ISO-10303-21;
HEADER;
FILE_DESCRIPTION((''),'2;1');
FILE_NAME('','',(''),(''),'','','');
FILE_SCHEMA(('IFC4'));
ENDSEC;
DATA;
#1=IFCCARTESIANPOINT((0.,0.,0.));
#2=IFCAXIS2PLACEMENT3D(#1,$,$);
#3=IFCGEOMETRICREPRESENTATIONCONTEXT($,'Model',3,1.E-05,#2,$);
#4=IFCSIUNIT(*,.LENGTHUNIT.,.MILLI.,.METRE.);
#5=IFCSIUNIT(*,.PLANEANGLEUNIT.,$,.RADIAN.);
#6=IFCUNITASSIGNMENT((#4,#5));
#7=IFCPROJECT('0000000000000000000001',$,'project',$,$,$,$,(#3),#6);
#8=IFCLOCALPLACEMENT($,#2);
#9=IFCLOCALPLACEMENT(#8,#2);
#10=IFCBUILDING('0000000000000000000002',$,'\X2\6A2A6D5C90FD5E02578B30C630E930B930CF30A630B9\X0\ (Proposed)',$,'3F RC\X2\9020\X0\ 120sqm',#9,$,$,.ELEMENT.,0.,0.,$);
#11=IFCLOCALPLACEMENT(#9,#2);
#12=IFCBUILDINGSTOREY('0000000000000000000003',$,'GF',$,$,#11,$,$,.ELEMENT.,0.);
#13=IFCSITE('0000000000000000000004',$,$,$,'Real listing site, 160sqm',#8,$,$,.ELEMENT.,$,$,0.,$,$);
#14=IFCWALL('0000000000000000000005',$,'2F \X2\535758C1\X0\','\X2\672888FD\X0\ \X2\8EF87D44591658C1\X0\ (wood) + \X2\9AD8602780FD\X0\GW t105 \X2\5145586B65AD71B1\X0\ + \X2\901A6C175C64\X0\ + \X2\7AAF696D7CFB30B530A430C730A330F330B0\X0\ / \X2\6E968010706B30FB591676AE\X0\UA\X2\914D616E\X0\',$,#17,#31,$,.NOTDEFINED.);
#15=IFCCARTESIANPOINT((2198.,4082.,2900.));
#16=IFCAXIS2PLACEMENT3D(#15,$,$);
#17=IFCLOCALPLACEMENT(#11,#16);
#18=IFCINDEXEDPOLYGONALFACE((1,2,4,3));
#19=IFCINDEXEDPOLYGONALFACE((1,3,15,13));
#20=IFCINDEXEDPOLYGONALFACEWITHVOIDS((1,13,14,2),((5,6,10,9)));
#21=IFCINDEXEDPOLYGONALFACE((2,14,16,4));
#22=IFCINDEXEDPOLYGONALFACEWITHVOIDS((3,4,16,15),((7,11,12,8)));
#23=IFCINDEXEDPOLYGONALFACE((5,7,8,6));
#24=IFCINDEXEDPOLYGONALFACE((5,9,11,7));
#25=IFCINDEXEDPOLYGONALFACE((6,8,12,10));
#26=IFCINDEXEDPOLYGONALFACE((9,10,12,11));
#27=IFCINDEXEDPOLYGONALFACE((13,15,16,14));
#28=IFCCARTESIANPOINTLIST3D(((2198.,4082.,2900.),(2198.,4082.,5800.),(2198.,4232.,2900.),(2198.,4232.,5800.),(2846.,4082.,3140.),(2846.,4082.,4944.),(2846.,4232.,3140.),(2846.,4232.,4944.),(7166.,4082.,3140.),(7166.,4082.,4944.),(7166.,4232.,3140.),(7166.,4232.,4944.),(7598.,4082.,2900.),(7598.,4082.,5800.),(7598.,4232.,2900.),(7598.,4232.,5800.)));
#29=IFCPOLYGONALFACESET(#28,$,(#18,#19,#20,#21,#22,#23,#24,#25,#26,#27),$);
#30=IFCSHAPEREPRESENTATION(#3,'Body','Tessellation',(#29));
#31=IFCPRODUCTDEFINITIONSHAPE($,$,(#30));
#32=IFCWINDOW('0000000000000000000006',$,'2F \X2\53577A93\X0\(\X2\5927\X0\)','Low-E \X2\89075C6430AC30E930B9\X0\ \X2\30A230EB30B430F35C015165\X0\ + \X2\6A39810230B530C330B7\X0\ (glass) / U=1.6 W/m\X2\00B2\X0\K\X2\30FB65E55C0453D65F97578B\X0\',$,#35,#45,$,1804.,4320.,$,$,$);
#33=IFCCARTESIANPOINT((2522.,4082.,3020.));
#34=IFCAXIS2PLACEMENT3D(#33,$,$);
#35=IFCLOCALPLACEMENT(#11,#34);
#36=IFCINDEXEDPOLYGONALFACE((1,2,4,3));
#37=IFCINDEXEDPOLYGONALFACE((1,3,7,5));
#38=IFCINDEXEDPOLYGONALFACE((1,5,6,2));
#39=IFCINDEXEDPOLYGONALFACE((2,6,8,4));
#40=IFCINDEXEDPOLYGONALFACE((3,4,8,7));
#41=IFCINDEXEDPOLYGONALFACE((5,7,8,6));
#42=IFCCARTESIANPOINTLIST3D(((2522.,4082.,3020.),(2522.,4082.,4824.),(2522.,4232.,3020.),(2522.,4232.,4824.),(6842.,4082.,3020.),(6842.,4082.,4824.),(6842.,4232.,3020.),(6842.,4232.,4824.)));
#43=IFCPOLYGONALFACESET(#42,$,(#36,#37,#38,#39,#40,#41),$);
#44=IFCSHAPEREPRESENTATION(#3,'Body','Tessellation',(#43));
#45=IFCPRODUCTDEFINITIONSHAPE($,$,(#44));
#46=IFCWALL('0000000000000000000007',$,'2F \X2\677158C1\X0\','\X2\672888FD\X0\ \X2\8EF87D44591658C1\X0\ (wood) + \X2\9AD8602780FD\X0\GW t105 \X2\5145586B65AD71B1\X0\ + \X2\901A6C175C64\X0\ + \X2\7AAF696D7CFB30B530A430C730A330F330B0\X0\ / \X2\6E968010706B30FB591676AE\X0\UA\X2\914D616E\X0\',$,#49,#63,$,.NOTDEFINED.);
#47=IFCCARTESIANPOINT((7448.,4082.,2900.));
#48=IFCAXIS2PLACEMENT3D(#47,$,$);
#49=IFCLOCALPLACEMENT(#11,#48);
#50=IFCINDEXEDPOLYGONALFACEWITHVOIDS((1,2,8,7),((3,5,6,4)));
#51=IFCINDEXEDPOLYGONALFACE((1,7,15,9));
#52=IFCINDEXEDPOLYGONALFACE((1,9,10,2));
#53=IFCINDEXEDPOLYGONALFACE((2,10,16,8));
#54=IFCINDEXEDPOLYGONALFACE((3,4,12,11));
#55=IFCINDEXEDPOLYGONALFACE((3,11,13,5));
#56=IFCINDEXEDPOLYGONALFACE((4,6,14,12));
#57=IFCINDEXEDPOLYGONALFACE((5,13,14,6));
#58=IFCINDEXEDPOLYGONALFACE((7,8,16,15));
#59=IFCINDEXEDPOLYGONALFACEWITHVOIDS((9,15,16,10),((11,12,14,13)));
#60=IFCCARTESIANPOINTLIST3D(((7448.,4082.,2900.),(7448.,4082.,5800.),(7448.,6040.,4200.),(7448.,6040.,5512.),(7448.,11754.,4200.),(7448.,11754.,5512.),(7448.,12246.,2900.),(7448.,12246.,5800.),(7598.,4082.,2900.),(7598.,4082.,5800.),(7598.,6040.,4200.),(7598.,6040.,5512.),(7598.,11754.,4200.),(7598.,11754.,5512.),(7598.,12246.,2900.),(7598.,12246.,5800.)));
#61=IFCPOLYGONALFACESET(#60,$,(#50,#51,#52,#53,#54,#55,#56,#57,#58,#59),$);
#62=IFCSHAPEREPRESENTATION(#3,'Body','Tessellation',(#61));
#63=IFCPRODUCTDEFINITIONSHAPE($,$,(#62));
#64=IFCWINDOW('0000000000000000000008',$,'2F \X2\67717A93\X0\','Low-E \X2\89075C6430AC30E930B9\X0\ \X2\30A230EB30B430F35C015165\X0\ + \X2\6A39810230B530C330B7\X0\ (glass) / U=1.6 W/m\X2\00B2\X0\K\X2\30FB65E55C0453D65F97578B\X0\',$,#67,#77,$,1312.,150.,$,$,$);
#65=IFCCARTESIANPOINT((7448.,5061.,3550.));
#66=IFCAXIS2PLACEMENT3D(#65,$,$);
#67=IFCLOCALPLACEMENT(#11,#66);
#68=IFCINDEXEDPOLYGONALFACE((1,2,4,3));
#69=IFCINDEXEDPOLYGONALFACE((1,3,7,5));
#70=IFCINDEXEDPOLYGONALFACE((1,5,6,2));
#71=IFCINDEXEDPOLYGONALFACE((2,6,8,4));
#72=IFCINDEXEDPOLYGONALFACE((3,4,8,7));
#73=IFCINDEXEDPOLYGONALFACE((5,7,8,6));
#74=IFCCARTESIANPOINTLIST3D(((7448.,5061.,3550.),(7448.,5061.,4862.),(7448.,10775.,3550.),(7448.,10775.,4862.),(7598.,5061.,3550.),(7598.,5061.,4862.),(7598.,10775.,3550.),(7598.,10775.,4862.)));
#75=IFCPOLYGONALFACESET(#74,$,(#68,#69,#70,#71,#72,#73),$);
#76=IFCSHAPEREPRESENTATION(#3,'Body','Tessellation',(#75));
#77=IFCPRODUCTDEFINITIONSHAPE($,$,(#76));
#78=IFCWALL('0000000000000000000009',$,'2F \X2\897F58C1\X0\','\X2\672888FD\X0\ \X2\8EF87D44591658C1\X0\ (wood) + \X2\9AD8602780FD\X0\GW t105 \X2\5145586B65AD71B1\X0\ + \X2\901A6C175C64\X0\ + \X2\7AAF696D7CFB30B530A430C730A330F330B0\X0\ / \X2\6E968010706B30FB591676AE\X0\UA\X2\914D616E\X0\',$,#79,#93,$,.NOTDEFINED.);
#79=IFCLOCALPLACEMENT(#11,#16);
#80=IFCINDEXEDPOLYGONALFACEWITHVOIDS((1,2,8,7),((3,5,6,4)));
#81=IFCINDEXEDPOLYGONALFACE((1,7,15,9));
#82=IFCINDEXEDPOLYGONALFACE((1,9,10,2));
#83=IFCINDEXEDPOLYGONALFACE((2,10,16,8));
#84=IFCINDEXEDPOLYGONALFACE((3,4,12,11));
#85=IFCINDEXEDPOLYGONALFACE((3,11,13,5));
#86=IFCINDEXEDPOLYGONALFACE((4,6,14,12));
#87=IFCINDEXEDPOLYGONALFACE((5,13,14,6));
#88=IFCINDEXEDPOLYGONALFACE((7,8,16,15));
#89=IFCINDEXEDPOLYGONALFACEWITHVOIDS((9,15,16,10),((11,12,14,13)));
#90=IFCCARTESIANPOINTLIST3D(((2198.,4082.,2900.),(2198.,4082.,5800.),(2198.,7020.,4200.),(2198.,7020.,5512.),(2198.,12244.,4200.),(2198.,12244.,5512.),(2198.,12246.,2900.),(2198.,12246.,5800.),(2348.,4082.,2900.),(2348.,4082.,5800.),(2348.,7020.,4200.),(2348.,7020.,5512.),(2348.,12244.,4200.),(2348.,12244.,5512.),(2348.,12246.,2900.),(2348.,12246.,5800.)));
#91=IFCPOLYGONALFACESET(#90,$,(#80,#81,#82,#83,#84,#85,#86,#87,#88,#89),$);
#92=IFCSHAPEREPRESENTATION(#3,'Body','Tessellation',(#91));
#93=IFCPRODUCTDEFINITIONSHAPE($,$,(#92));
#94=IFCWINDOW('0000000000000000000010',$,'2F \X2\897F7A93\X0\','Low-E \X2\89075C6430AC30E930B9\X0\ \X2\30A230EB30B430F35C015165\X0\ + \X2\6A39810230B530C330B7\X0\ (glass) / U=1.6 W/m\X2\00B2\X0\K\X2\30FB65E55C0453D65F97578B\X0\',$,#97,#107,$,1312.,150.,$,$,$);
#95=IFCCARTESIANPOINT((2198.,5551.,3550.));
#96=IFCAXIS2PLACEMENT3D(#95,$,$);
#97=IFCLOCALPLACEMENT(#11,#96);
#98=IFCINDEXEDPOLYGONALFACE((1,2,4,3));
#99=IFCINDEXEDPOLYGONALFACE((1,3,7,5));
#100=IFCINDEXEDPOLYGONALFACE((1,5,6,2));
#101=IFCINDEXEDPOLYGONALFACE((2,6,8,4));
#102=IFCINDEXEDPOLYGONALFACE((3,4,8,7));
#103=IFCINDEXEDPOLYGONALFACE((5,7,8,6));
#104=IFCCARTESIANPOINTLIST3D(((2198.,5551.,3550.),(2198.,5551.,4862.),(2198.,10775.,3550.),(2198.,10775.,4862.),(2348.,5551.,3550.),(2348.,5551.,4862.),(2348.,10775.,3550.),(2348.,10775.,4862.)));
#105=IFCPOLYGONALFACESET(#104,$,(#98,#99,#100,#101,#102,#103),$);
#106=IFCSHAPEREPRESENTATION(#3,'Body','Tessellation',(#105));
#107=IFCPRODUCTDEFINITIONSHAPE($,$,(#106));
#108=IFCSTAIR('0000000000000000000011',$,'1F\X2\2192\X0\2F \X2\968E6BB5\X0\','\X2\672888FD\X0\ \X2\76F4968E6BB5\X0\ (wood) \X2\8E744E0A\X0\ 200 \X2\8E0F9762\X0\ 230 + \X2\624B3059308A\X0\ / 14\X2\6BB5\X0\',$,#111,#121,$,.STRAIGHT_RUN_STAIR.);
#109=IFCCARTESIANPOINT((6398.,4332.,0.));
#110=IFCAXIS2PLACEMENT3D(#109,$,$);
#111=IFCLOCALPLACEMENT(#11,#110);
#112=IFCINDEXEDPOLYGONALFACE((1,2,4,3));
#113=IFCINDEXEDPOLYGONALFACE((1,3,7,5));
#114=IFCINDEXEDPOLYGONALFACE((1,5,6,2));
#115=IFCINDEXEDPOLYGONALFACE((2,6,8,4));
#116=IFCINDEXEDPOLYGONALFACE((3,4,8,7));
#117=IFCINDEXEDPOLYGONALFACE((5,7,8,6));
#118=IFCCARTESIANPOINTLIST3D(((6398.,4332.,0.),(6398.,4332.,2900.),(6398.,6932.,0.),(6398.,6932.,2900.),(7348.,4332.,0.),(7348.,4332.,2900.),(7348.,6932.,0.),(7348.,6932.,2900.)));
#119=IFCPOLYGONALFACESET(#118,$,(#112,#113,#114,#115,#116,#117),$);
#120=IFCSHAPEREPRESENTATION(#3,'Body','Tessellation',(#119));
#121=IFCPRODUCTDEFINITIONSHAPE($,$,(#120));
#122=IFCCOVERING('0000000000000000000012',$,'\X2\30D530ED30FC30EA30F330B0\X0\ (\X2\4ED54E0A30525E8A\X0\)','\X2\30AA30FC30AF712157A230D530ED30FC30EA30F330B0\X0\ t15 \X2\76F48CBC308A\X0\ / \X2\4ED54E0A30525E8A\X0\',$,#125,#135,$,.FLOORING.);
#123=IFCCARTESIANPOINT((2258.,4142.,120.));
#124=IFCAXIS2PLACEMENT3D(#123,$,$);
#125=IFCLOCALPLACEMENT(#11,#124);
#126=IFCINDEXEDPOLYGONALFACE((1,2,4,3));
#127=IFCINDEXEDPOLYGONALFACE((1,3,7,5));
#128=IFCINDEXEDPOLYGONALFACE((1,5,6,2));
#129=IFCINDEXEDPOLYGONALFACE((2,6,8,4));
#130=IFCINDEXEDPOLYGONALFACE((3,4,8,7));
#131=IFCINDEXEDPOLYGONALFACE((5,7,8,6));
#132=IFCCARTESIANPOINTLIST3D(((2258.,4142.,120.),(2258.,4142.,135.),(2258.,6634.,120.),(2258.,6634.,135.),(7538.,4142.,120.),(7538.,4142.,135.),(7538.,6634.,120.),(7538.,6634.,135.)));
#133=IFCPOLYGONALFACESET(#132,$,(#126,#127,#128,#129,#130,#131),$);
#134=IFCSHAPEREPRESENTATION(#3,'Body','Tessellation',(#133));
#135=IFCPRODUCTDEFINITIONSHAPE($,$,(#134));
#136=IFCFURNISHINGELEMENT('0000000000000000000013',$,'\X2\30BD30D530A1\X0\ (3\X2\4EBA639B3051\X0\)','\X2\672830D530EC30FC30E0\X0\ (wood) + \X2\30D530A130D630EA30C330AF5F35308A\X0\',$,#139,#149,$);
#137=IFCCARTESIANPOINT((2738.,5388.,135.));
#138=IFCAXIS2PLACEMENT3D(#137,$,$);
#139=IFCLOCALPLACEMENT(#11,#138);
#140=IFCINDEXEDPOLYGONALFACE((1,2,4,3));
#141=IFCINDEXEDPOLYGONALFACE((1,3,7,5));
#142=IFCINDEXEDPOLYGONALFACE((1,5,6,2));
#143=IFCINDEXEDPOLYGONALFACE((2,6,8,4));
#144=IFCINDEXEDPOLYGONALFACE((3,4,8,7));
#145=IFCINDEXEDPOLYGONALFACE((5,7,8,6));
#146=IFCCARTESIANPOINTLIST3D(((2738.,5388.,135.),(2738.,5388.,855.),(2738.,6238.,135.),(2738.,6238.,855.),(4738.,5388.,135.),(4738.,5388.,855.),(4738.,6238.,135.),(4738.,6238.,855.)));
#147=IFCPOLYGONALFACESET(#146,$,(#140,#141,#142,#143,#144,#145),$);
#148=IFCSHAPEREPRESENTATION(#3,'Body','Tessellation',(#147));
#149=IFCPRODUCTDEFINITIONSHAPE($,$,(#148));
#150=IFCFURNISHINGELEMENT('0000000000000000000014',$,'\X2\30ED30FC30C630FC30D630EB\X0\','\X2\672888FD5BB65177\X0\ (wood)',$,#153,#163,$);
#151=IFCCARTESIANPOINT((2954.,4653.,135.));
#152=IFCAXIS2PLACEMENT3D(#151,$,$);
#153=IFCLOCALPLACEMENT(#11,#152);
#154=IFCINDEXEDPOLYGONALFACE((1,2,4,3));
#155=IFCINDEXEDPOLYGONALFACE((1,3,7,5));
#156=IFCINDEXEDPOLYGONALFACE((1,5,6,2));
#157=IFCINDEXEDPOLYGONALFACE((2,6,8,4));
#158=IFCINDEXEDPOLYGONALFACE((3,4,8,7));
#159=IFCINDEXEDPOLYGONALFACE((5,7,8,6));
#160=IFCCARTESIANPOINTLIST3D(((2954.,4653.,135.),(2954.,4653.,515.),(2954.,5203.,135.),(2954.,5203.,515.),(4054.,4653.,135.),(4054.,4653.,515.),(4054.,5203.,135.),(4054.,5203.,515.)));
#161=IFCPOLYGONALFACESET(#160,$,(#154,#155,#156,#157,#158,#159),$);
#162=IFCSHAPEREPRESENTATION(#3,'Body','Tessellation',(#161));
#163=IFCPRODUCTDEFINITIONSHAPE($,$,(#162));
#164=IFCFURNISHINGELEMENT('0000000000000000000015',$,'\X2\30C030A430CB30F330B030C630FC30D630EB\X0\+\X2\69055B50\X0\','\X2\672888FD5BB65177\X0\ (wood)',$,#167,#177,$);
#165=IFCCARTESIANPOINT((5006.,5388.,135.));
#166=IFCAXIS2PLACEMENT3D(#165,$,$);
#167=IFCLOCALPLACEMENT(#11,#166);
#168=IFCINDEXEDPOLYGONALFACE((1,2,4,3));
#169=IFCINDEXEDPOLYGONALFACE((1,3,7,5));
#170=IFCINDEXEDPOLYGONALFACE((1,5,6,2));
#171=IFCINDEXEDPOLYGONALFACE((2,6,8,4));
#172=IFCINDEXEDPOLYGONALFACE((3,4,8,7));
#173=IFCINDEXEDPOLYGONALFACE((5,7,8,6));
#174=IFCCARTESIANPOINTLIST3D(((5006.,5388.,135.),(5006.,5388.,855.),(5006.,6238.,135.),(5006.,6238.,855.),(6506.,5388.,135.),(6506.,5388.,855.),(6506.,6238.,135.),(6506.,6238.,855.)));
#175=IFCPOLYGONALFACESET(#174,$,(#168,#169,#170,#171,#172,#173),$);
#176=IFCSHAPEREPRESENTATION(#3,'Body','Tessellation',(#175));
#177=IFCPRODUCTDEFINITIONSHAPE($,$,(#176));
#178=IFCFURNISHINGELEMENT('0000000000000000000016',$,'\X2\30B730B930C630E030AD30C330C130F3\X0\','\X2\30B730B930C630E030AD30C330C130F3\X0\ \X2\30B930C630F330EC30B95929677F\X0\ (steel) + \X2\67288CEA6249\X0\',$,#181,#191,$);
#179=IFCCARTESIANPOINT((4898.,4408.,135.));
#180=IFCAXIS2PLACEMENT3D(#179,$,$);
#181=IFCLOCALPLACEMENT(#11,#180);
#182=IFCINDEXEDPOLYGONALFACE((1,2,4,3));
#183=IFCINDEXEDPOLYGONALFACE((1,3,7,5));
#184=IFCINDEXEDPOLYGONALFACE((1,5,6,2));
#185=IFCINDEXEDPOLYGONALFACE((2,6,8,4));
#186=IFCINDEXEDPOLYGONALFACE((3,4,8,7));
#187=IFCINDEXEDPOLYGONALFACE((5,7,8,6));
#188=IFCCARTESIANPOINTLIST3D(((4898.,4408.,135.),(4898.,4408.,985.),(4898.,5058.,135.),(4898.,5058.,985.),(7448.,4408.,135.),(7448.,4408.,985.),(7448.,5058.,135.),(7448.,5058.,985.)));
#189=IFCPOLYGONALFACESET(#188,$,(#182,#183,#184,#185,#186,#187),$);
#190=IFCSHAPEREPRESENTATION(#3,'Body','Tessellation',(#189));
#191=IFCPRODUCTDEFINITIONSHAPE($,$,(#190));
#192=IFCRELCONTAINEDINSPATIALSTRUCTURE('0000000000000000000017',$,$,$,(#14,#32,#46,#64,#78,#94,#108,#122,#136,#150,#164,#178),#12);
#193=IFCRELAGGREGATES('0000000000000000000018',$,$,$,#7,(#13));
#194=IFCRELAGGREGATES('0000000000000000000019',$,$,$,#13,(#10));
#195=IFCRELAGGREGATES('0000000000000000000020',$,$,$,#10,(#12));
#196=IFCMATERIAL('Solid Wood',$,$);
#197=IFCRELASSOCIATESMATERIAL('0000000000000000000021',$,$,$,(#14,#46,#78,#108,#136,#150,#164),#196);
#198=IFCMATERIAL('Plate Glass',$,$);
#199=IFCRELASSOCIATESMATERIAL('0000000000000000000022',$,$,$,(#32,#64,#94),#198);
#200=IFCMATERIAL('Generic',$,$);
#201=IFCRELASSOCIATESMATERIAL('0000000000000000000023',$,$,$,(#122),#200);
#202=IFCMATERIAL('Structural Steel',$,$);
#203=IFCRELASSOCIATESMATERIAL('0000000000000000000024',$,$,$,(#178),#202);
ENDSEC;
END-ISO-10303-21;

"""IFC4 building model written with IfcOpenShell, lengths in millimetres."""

from ifc_helpers import new_model, si_unit, frame, frame_2d, origin, place, context, project, spatial, rectangle, extrude, material, element, fill, save


model = new_model("IFC4")

# Units and contexts
model_context = context("Model", 3, precision=1e-05, world=origin())
ifc_project = project(units=[si_unit("LENGTHUNIT", "METRE", prefix="MILLI"), si_unit("PLANEANGLEUNIT", "RADIAN")], contexts=[model_context])

# Site, building, storey
site_placement = place(None, origin())
site = spatial("IfcSite", under=ifc_project, at=site_placement, ObjectType="Real listing site, 160sqm", CompositionType="ELEMENT", RefElevation=0.0)
building_placement = place(site_placement, origin())
building = spatial("IfcBuilding", under=site, at=building_placement, Name="横浜都市型テラスハウス (Proposed)", ObjectType="3F RC造 120sqm", CompositionType="ELEMENT", ElevationOfRefHeight=0.0, ElevationOfTerrain=0.0)
storey_placement = place(building_placement, origin())
storey = spatial("IfcBuildingStorey", under=building, at=storey_placement, Name="GF", CompositionType="ELEMENT", Elevation=0.0)

# Shared definitions
ifc_material_1 = material(Name="Solid Wood")

# Shared definitions
ifc_material_2 = material(Name="Plate Glass")

# Walls, openings, windows
wall_1_placement = place(storey_placement, frame((2198.0, 4082.0, 2900.0)))
wall_1 = element("IfcWall", 1, at=wall_1_placement, inside=storey, material=ifc_material_1, Name="2F 南壁", Description="木製 軸組外壁 (wood) + 高性能GW t105 充填断熱 + 通気層 + 窯業系サイディング / 準耐火・外皮UA配慮", PredefinedType="NOTDEFINED", context=model_context, shape_type="SweptSolid", body=[
    extrude(rectangle(XDim=5400.0, YDim=150.0, at=frame_2d((2700.0, 75.0))), frame((2198.0, 4082.0, 2900.0)), (0.0, 0.0, 1.0), 2900.0),
])
opening_1_placement = place(storey_placement, frame((2522.0, 4082.0, 3020.0)))
opening_1 = element("IfcOpeningElement", 2, at=opening_1_placement, cuts=wall_1, PredefinedType="NOTDEFINED", context=model_context, shape_type="SweptSolid", body=[
    extrude(rectangle(XDim=4320.0, YDim=150.0, at=frame_2d((2160.0, 75.0))), frame((2522.0, 4082.0, 3020.0)), (0.0, 0.0, 1.0), 1804.0),
])
window_1_placement = place(storey_placement, frame((2522.0, 4082.0, 3020.0)))
window_1 = element("IfcWindow", 3, at=window_1_placement, inside=storey, material=ifc_material_2, Name="2F 南窓(大)", Description="Low-E 複層ガラス アルゴン封入 + 樹脂サッシ (glass) / U=1.6 W/m²K・日射取得型", OverallHeight=1804.0, OverallWidth=4320.0, context=model_context, shape_type="SweptSolid", body=[
    extrude(rectangle(XDim=4320.0, YDim=150.0, at=frame_2d((2160.0, 75.0))), frame((2522.0, 4082.0, 3020.0)), (0.0, 0.0, 1.0), 1804.0),
])
fill(opening_1, window_1)
wall_2_placement = place(storey_placement, frame((7448.0, 4082.0, 2900.0)))
wall_2 = element("IfcWall", 4, at=wall_2_placement, inside=storey, material=ifc_material_1, Name="2F 東壁", Description="木製 軸組外壁 (wood) + 高性能GW t105 充填断熱 + 通気層 + 窯業系サイディング / 準耐火・外皮UA配慮", PredefinedType="NOTDEFINED", context=model_context, shape_type="SweptSolid", body=[
    extrude(rectangle(XDim=150.0, YDim=8164.0, at=frame_2d((75.0, 4082.0))), frame((7448.0, 4082.0, 2900.0)), (0.0, 0.0, 1.0), 2900.0),
])
opening_2_placement = place(storey_placement, frame((7448.0, 5061.0, 3550.0)))
opening_2 = element("IfcOpeningElement", 5, at=opening_2_placement, cuts=wall_2, PredefinedType="NOTDEFINED", context=model_context, shape_type="SweptSolid", body=[
    extrude(rectangle(XDim=150.0, YDim=5714.0, at=frame_2d((75.0, 2857.0))), frame((7448.0, 5061.0, 3550.0)), (0.0, 0.0, 1.0), 1312.0),
])
window_2_placement = place(storey_placement, frame((7448.0, 5061.0, 3550.0)))
window_2 = element("IfcWindow", 6, at=window_2_placement, inside=storey, material=ifc_material_2, Name="2F 東窓", Description="Low-E 複層ガラス アルゴン封入 + 樹脂サッシ (glass) / U=1.6 W/m²K・日射取得型", OverallHeight=1312.0, OverallWidth=150.0, context=model_context, shape_type="SweptSolid", body=[
    extrude(rectangle(XDim=150.0, YDim=5714.0, at=frame_2d((75.0, 2857.0))), frame((7448.0, 5061.0, 3550.0)), (0.0, 0.0, 1.0), 1312.0),
])
fill(opening_2, window_2)
wall_3_placement = place(storey_placement, frame((2198.0, 4082.0, 2900.0)))
wall_3 = element("IfcWall", 7, at=wall_3_placement, inside=storey, material=ifc_material_1, Name="2F 西壁", Description="木製 軸組外壁 (wood) + 高性能GW t105 充填断熱 + 通気層 + 窯業系サイディング / 準耐火・外皮UA配慮", PredefinedType="NOTDEFINED", context=model_context, shape_type="SweptSolid", body=[
    extrude(rectangle(XDim=150.0, YDim=8164.0, at=frame_2d((75.0, 4082.0))), frame((2198.0, 4082.0, 2900.0)), (0.0, 0.0, 1.0), 2900.0),
])
opening_3_placement = place(storey_placement, frame((2198.0, 5551.0, 3550.0)))
opening_3 = element("IfcOpeningElement", 8, at=opening_3_placement, cuts=wall_3, PredefinedType="NOTDEFINED", context=model_context, shape_type="SweptSolid", body=[
    extrude(rectangle(XDim=150.0, YDim=5224.0, at=frame_2d((75.0, 2612.0))), frame((2198.0, 5551.0, 3550.0)), (0.0, 0.0, 1.0), 1312.0),
])
window_3_placement = place(storey_placement, frame((2198.0, 5551.0, 3550.0)))
window_3 = element("IfcWindow", 9, at=window_3_placement, inside=storey, material=ifc_material_2, Name="2F 西窓", Description="Low-E 複層ガラス アルゴン封入 + 樹脂サッシ (glass) / U=1.6 W/m²K・日射取得型", OverallHeight=1312.0, OverallWidth=150.0, context=model_context, shape_type="SweptSolid", body=[
    extrude(rectangle(XDim=150.0, YDim=5224.0, at=frame_2d((75.0, 2612.0))), frame((2198.0, 5551.0, 3550.0)), (0.0, 0.0, 1.0), 1312.0),
])
fill(opening_3, window_3)

# Stair
stair_placement = place(storey_placement, frame((6398.0, 4332.0, 0.0)))
element("IfcStair", 10, at=stair_placement, inside=storey, material=ifc_material_1, Name="1F→2F 階段", Description="木製 直階段 (wood) 蹴上 200 踏面 230 + 手すり / 14段", PredefinedType="STRAIGHT_RUN_STAIR", context=model_context, shape_type="SweptSolid", body=[
    extrude(rectangle(XDim=950.0, YDim=2600.0, at=frame_2d((475.0, 1300.0))), frame((6398.0, 4332.0, 0.0)), (0.0, 0.0, 1.0), 2900.0),
])

# Covering
ifc_material_3 = material(Name="Generic")
covering_placement = place(storey_placement, frame((2258.0, 4142.0, 120.0)))
element("IfcCovering", 11, at=covering_placement, inside=storey, material=ifc_material_3, Name="フローリング (仕上げ床)", Description="オーク無垢フローリング t15 直貼り / 仕上げ床", PredefinedType="FLOORING", context=model_context, shape_type="SweptSolid", body=[
    extrude(rectangle(XDim=5280.0, YDim=2492.0, at=frame_2d((2640.0, 1246.0))), frame((2258.0, 4142.0, 120.0)), (0.0, 0.0, 1.0), 15.0),
])

# Furnishing elements
furnishing_1_placement = place(storey_placement, frame((2738.0, 5388.0, 135.0)))
element("IfcFurnishingElement", 12, at=furnishing_1_placement, inside=storey, material=ifc_material_1, Name="ソファ (3人掛け)", Description="木フレーム (wood) + ファブリック張り", context=model_context, shape_type="SweptSolid", body=[
    extrude(rectangle(XDim=2000.0, YDim=850.0, at=frame_2d((1000.0, 425.0))), frame((2738.0, 5388.0, 135.0)), (0.0, 0.0, 1.0), 720.0),
])
furnishing_2_placement = place(storey_placement, frame((2954.0, 4653.0, 135.0)))
element("IfcFurnishingElement", 13, at=furnishing_2_placement, inside=storey, material=ifc_material_1, Name="ローテーブル", Description="木製家具 (wood)", context=model_context, shape_type="SweptSolid", body=[
    extrude(rectangle(XDim=1100.0, YDim=550.0, at=frame_2d((550.0, 275.0))), frame((2954.0, 4653.0, 135.0)), (0.0, 0.0, 1.0), 380.0),
])
furnishing_3_placement = place(storey_placement, frame((5006.0, 5388.0, 135.0)))
element("IfcFurnishingElement", 14, at=furnishing_3_placement, inside=storey, material=ifc_material_1, Name="ダイニングテーブル+椅子", Description="木製家具 (wood)", context=model_context, shape_type="SweptSolid", body=[
    extrude(rectangle(XDim=1500.0, YDim=850.0, at=frame_2d((750.0, 425.0))), frame((5006.0, 5388.0, 135.0)), (0.0, 0.0, 1.0), 720.0),
])
ifc_material_4 = material(Name="Structural Steel")
furnishing_4_placement = place(storey_placement, frame((4898.0, 4408.0, 135.0)))
element("IfcFurnishingElement", 15, at=furnishing_4_placement, inside=storey, material=ifc_material_4, Name="システムキッチン", Description="システムキッチン ステンレス天板 (steel) + 木質扉", context=model_context, shape_type="SweptSolid", body=[
    extrude(rectangle(XDim=2550.0, YDim=650.0, at=frame_2d((1275.0, 325.0))), frame((4898.0, 4408.0, 135.0)), (0.0, 0.0, 1.0), 850.0),
])

save(model, "model.ifc")
